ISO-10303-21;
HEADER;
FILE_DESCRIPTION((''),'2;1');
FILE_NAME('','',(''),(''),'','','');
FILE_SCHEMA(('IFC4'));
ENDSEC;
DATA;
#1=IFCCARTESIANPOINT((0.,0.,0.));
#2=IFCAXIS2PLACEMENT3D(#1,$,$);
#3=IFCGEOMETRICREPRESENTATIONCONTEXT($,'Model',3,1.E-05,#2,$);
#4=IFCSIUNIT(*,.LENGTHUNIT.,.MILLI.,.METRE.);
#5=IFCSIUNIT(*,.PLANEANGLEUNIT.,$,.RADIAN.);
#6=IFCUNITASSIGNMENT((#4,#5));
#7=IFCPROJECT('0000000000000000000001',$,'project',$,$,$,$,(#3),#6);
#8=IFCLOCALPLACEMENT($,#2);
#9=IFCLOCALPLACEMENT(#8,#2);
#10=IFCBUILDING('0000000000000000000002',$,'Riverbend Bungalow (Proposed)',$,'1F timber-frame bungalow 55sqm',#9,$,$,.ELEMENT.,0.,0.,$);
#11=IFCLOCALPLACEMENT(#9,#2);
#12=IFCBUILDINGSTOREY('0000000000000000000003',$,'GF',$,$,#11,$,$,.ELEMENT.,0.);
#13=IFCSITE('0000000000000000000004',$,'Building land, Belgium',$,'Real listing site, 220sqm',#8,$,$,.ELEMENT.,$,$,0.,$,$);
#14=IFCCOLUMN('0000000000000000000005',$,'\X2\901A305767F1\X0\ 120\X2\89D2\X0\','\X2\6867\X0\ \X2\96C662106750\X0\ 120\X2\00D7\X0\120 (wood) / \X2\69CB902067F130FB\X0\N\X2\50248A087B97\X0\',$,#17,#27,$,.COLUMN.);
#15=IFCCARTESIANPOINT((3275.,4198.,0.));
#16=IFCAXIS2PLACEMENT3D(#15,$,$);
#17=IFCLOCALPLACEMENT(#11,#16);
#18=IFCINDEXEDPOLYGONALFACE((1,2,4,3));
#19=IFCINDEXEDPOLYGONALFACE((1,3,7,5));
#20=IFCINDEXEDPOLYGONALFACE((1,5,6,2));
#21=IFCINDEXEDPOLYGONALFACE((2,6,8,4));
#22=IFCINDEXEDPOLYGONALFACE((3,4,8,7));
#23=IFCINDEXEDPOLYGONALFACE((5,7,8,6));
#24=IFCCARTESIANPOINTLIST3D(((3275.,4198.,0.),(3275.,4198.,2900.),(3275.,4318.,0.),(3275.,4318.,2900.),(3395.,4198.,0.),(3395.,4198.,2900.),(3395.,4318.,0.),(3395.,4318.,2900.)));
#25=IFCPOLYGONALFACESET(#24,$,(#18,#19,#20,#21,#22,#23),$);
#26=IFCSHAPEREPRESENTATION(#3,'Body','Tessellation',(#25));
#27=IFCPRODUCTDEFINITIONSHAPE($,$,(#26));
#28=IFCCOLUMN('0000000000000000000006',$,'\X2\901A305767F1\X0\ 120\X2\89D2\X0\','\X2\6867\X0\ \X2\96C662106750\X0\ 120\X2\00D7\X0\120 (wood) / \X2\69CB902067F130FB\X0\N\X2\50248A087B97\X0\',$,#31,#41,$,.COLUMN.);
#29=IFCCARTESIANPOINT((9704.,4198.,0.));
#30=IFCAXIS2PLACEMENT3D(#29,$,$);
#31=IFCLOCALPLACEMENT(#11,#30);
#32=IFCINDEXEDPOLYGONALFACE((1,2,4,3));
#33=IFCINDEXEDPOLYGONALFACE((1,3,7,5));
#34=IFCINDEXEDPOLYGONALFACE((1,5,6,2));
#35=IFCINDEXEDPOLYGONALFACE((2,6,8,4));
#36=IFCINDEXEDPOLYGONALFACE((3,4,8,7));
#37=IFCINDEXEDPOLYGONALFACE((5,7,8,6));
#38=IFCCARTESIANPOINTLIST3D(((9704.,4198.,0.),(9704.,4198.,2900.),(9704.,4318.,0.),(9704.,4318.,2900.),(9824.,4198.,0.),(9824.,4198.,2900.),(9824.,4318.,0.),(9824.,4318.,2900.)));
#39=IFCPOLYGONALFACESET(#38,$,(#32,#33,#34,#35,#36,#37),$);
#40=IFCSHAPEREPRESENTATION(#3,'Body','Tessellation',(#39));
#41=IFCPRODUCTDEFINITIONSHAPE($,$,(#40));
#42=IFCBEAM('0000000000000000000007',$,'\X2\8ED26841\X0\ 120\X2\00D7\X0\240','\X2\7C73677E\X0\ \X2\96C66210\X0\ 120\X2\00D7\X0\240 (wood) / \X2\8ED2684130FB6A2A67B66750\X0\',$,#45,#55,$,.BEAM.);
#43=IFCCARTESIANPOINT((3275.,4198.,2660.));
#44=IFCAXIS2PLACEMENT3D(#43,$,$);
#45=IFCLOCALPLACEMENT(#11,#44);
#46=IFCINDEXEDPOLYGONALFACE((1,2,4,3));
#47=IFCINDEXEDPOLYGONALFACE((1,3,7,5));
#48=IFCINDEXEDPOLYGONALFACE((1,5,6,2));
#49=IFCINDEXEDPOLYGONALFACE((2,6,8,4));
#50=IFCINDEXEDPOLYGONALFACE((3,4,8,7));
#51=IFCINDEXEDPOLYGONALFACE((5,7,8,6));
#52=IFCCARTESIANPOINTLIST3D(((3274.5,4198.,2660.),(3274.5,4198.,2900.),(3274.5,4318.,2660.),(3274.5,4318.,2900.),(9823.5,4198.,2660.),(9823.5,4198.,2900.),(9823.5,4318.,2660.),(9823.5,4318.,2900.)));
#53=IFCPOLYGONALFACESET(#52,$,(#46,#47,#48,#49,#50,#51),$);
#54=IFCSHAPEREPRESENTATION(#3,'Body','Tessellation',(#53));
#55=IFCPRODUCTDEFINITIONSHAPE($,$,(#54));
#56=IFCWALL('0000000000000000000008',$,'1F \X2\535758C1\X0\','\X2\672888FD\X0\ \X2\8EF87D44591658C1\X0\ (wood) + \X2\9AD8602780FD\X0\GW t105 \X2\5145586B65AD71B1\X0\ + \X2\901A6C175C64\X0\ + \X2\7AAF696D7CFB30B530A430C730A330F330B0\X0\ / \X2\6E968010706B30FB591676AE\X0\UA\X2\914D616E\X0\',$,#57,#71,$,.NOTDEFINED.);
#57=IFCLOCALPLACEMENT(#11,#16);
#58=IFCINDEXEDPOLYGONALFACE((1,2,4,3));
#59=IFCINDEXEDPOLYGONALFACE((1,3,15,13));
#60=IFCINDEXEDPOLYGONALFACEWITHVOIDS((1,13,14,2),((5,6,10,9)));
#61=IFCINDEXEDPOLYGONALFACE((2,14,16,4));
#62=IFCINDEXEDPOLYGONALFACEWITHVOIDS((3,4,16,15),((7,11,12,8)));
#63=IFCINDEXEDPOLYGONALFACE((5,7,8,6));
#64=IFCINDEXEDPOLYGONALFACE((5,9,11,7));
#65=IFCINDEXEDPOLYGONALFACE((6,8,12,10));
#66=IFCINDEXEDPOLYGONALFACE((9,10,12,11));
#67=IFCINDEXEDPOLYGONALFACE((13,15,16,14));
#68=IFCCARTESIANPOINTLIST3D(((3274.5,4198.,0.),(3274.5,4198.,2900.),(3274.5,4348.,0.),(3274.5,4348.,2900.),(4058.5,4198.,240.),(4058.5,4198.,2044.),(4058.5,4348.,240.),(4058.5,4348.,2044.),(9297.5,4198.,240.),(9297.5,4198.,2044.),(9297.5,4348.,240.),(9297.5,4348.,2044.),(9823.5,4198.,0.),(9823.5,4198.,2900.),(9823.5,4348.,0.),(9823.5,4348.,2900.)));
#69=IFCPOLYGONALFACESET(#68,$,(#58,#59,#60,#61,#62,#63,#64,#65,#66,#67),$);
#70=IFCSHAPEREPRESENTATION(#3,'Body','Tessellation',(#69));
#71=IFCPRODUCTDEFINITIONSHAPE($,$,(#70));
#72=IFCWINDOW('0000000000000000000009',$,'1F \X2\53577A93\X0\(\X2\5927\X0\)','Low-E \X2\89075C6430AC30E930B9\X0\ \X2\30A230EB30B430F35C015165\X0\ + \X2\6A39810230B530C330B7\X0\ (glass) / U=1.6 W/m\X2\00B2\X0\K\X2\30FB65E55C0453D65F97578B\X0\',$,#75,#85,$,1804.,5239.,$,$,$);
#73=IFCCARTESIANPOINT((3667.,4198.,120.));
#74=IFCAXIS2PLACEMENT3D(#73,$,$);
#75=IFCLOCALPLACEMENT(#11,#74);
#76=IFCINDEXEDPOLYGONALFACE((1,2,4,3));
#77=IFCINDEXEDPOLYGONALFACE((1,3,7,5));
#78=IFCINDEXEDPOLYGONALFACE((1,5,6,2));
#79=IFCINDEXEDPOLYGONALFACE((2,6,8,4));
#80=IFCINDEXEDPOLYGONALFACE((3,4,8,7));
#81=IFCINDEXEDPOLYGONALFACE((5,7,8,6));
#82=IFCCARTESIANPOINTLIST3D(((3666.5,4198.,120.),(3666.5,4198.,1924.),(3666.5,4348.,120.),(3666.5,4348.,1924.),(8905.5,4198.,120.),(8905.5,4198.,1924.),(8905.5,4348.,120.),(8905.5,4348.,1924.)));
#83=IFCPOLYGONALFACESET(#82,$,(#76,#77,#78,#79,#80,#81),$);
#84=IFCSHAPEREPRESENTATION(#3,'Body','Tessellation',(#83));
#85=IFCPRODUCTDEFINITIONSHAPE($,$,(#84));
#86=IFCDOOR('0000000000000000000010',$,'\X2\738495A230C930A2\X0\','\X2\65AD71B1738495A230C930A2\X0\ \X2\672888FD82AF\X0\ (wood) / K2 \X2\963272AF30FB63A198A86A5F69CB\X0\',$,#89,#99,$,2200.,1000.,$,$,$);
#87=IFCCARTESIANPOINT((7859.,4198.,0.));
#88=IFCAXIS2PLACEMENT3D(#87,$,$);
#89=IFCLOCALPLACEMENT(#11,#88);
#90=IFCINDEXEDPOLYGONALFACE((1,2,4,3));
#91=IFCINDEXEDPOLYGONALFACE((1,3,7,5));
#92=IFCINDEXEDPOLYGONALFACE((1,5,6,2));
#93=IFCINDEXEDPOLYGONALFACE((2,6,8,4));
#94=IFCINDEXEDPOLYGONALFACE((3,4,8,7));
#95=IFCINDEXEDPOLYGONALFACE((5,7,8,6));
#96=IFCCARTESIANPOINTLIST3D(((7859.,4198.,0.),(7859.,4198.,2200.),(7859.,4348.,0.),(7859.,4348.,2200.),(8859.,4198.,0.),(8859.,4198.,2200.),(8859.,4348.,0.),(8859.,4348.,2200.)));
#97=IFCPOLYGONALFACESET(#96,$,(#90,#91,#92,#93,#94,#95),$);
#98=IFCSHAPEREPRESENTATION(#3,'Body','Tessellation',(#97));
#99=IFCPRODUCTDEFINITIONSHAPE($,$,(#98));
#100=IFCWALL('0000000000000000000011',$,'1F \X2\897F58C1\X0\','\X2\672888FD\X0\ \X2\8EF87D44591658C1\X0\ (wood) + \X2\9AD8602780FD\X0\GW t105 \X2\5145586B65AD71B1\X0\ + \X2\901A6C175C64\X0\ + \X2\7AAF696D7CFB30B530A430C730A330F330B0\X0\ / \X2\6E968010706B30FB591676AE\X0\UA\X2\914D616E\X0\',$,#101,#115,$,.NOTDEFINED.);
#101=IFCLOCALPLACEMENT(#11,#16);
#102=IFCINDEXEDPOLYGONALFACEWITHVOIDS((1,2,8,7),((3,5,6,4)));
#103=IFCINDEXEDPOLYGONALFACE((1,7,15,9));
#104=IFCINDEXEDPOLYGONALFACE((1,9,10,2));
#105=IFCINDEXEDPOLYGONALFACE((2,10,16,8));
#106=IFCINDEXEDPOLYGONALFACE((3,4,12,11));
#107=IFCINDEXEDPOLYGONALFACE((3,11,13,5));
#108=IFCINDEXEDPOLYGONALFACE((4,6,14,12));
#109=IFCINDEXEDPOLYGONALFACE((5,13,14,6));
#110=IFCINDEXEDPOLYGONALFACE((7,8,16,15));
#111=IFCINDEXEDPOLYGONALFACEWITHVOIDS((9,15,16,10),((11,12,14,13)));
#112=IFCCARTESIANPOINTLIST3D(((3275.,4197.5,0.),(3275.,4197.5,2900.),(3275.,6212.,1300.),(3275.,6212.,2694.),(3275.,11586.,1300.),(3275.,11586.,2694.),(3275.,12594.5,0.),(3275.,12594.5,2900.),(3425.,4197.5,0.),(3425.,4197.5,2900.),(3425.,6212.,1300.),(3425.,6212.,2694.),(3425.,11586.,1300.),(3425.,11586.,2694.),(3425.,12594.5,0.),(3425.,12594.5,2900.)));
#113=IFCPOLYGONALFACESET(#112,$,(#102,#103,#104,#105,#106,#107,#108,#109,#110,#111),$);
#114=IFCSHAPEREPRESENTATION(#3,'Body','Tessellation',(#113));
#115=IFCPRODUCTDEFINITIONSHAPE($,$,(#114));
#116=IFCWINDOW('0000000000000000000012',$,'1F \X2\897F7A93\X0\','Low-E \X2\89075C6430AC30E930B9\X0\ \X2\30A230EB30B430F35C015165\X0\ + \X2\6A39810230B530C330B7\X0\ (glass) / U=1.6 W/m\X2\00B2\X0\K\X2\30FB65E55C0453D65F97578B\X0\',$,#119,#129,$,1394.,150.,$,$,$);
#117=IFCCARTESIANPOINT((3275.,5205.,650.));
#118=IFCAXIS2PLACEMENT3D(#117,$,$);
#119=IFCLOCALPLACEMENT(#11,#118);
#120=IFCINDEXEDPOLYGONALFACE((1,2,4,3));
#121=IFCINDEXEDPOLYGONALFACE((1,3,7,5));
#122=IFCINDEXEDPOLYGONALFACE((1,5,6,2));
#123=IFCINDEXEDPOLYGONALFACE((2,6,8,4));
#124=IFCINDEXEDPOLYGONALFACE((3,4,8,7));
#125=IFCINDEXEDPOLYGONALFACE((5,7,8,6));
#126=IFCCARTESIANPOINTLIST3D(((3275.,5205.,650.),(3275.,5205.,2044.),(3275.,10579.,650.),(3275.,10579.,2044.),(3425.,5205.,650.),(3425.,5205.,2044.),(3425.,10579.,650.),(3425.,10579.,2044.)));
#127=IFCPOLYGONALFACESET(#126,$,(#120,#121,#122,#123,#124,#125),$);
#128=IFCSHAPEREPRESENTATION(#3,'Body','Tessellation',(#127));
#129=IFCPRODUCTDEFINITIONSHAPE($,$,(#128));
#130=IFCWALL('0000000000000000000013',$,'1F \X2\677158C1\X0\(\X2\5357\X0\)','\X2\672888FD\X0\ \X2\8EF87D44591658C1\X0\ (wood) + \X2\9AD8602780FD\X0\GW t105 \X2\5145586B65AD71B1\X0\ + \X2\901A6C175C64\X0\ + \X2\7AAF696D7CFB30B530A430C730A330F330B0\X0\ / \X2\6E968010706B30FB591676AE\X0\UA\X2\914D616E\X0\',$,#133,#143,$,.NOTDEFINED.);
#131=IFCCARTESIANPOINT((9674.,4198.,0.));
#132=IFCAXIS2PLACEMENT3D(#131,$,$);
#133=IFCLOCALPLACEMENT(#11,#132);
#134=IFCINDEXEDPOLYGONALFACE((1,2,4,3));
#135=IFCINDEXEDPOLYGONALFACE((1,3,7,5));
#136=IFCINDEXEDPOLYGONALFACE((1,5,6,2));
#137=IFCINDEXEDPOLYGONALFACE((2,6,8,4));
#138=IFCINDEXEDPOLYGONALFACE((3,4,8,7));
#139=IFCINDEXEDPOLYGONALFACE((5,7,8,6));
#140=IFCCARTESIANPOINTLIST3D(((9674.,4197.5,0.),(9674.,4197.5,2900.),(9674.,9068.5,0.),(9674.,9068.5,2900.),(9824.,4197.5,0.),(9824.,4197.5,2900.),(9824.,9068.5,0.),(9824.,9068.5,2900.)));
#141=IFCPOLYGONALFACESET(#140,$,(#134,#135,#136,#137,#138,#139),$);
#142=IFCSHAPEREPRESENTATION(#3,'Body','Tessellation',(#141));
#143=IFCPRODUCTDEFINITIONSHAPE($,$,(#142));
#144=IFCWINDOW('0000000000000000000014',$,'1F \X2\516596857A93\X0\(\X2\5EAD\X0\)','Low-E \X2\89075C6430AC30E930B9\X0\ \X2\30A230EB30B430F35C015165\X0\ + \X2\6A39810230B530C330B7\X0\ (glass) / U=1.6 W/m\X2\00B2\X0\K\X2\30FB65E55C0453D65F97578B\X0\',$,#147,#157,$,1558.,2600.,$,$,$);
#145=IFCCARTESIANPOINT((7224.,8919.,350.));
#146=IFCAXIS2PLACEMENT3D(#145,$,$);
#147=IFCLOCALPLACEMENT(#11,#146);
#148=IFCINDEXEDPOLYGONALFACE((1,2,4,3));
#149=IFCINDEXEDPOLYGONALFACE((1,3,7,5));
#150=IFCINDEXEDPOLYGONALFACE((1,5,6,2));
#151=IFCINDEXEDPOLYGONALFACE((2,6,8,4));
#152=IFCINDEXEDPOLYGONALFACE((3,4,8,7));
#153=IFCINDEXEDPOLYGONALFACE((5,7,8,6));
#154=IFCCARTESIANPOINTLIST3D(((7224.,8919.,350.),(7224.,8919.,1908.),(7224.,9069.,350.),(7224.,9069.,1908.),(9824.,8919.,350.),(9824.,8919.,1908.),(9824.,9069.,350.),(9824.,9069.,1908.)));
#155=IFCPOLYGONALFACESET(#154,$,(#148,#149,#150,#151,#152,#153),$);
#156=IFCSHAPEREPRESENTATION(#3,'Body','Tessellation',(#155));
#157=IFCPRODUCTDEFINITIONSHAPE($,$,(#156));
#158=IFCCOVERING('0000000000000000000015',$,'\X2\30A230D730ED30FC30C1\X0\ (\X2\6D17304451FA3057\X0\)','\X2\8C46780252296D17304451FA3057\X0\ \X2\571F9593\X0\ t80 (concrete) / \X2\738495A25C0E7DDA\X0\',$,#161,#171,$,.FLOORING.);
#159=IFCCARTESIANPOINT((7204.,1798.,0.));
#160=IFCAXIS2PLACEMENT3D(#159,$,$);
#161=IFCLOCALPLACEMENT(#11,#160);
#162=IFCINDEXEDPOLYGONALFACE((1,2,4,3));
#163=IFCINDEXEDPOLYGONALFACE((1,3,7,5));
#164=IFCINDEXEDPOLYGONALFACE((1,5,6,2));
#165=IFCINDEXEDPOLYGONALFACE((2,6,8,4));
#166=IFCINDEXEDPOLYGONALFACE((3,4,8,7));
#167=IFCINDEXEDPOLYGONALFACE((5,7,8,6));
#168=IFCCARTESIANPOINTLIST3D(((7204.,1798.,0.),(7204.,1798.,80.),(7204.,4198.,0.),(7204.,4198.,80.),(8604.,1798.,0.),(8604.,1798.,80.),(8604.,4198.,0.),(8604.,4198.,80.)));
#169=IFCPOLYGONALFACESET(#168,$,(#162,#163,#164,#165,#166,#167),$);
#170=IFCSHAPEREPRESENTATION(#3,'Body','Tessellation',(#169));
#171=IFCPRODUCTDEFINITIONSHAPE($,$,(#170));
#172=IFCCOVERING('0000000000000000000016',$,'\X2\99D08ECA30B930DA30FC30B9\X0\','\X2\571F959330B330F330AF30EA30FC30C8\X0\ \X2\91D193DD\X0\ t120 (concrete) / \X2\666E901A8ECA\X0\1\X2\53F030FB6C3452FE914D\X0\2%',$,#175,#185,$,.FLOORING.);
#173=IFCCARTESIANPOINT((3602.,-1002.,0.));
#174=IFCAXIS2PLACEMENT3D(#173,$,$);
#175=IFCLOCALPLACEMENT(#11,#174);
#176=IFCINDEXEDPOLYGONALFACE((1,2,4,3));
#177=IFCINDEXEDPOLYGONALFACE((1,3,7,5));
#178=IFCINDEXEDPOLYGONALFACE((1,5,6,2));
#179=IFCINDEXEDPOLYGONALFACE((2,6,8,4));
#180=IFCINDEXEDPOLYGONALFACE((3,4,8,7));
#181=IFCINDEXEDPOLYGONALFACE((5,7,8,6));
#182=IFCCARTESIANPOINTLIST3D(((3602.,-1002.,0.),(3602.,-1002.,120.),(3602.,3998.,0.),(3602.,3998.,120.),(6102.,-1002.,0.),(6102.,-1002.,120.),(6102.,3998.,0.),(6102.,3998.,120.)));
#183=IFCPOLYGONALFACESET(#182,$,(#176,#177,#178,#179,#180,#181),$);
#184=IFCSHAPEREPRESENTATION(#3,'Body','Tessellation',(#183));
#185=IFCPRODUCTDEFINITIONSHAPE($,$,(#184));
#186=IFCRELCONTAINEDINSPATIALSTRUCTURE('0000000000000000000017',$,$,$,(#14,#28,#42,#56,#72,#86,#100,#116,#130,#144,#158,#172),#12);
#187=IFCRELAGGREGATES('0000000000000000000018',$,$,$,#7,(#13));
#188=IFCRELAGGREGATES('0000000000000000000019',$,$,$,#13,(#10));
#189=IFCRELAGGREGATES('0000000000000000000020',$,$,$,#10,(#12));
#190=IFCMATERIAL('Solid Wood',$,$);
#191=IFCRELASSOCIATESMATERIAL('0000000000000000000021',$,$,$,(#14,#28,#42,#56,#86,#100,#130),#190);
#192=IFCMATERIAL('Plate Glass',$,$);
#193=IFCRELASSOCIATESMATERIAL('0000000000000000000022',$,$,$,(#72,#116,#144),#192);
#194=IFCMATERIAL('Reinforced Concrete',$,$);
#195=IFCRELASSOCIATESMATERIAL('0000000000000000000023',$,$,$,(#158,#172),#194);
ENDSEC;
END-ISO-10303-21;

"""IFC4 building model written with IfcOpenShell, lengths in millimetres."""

from ifc_helpers import new_model, si_unit, frame, frame_2d, origin, place, context, project, spatial, rectangle, extrude, material, element, fill, save


model = new_model("IFC4")

# Units and contexts
model_context = context("Model", 3, precision=1e-05, world=origin())
ifc_project = project(units=[si_unit("LENGTHUNIT", "METRE", prefix="MILLI"), si_unit("PLANEANGLEUNIT", "RADIAN")], contexts=[model_context])

# Site, building, storey
site_placement = place(None, origin())
site = spatial("IfcSite", under=ifc_project, at=site_placement, Name="Building land, Belgium", ObjectType="Real listing site, 220sqm", CompositionType="ELEMENT", RefElevation=0.0)
building_placement = place(site_placement, origin())
building = spatial("IfcBuilding", under=site, at=building_placement, Name="Riverbend Bungalow (Proposed)", ObjectType="1F timber-frame bungalow 55sqm", CompositionType="ELEMENT", ElevationOfRefHeight=0.0, ElevationOfTerrain=0.0)
storey_placement = place(building_placement, origin())
storey = spatial("IfcBuildingStorey", under=building, at=storey_placement, Name="GF", CompositionType="ELEMENT", Elevation=0.0)

# Columns
ifc_material_1 = material(Name="Solid Wood")
column_1_placement = place(storey_placement, frame((3275.0, 4198.0, 0.0)))
element("IfcColumn", 1, at=column_1_placement, inside=storey, material=ifc_material_1, Name="通し柱 120角", Description="桧 集成材 120×120 (wood) / 構造柱・N値計算", PredefinedType="COLUMN", context=model_context, shape_type="SweptSolid", body=[
    extrude(rectangle(XDim=120.0, YDim=120.0, at=frame_2d((60.0, 60.0))), frame((3275.0, 4198.0, 0.0)), (0.0, 0.0, 1.0), 2900.0),
])
column_2_placement = place(storey_placement, frame((9704.0, 4198.0, 0.0)))
element("IfcColumn", 2, at=column_2_placement, inside=storey, material=ifc_material_1, Name="通し柱 120角", Description="桧 集成材 120×120 (wood) / 構造柱・N値計算", PredefinedType="COLUMN", context=model_context, shape_type="SweptSolid", body=[
    extrude(rectangle(XDim=120.0, YDim=120.0, at=frame_2d((60.0, 60.0))), frame((9704.0, 4198.0, 0.0)), (0.0, 0.0, 1.0), 2900.0),
])

# Beam
beam_1_placement = place(storey_placement, frame((3275.0, 4198.0, 2660.0)))
element("IfcBeam", 3, at=beam_1_placement, inside=storey, material=ifc_material_1, Name="軒桁 120×240", Description="米松 集成 120×240 (wood) / 軒桁・横架材", PredefinedType="BEAM", context=model_context, shape_type="SweptSolid", body=[
    extrude(rectangle(XDim=6549.0, YDim=120.0, at=frame_2d((3274.0, 60.0))), frame((3275.0, 4198.0, 2660.0)), (0.0, 0.0, 1.0), 240.0),
])

# Shared definitions
ifc_material_2 = material(Name="Reinforced Concrete")

# Wall, openings, window, door
wall_1_placement = place(storey_placement, frame((3275.0, 4198.0, 0.0)))
wall_1 = element("IfcWall", 4, at=wall_1_placement, inside=storey, material=ifc_material_1, Name="1F 南壁", Description="木製 軸組外壁 (wood) + 高性能GW t105 充填断熱 + 通気層 + 窯業系サイディング / 準耐火・外皮UA配慮", PredefinedType="NOTDEFINED", context=model_context, shape_type="SweptSolid", body=[
    extrude(rectangle(XDim=6549.0, YDim=150.0, at=frame_2d((3274.0, 75.0))), frame((3275.0, 4198.0, 0.0)), (0.0, 0.0, 1.0), 2900.0),
])
opening_1_placement = place(storey_placement, frame((3667.0, 4198.0, 120.0)))
opening_1 = element("IfcOpeningElement", 5, at=opening_1_placement, cuts=wall_1, PredefinedType="NOTDEFINED", context=model_context, shape_type="SweptSolid", body=[
    extrude(rectangle(XDim=5239.0, YDim=150.0, at=frame_2d((2619.0, 75.0))), frame((3667.0, 4198.0, 120.0)), (0.0, 0.0, 1.0), 1804.0),
])
opening_2_placement = place(storey_placement, frame((7859.0, 4198.0, 0.0)))
opening_2 = element("IfcOpeningElement", 6, at=opening_2_placement, cuts=wall_1, PredefinedType="NOTDEFINED", context=model_context, shape_type="SweptSolid", body=[
    extrude(rectangle(XDim=1000.0, YDim=150.0, at=frame_2d((500.0, 75.0))), frame((7859.0, 4198.0, 0.0)), (0.0, 0.0, 1.0), 2200.0),
])
ifc_material_3 = material(Name="Plate Glass")
window_1_placement = place(storey_placement, frame((3667.0, 4198.0, 120.0)))
window_1 = element("IfcWindow", 7, at=window_1_placement, inside=storey, material=ifc_material_3, Name="1F 南窓(大)", Description="Low-E 複層ガラス アルゴン封入 + 樹脂サッシ (glass) / U=1.6 W/m²K・日射取得型", OverallHeight=1804.0, OverallWidth=5239.0, context=model_context, shape_type="SweptSolid", body=[
    extrude(rectangle(XDim=5239.0, YDim=150.0, at=frame_2d((2619.0, 75.0))), frame((3667.0, 4198.0, 120.0)), (0.0, 0.0, 1.0), 1804.0),
])
fill(opening_1, window_1)
door_1_placement = place(storey_placement, frame((7859.0, 4198.0, 0.0)))
door_1 = element("IfcDoor", 8, at=door_1_placement, inside=storey, material=ifc_material_1, Name="玄関ドア", Description="断熱玄関ドア 木製芯 (wood) / K2 防犯・採風機構", OverallHeight=2200.0, OverallWidth=1000.0, context=model_context, shape_type="SweptSolid", body=[
    extrude(rectangle(XDim=1000.0, YDim=150.0, at=frame_2d((500.0, 75.0))), frame((7859.0, 4198.0, 0.0)), (0.0, 0.0, 1.0), 2200.0),
])
fill(opening_2, door_1)

# Walls, openings, windows
wall_2_placement = place(storey_placement, frame((3275.0, 4198.0, 0.0)))
wall_2 = element("IfcWall", 9, at=wall_2_placement, inside=storey, material=ifc_material_1, Name="1F 西壁", Description="木製 軸組外壁 (wood) + 高性能GW t105 充填断熱 + 通気層 + 窯業系サイディング / 準耐火・外皮UA配慮", PredefinedType="NOTDEFINED", context=model_context, shape_type="SweptSolid", body=[
    extrude(rectangle(XDim=150.0, YDim=8397.0, at=frame_2d((75.0, 4198.0))), frame((3275.0, 4198.0, 0.0)), (0.0, 0.0, 1.0), 2900.0),
])
opening_3_placement = place(storey_placement, frame((3275.0, 5205.0, 650.0)))
opening_3 = element("IfcOpeningElement", 10, at=opening_3_placement, cuts=wall_2, PredefinedType="NOTDEFINED", context=model_context, shape_type="SweptSolid", body=[
    extrude(rectangle(XDim=150.0, YDim=5374.0, at=frame_2d((75.0, 2687.0))), frame((3275.0, 5205.0, 650.0)), (0.0, 0.0, 1.0), 1394.0),
])
window_2_placement = place(storey_placement, frame((3275.0, 5205.0, 650.0)))
window_2 = element("IfcWindow", 11, at=window_2_placement, inside=storey, material=ifc_material_3, Name="1F 西窓", Description="Low-E 複層ガラス アルゴン封入 + 樹脂サッシ (glass) / U=1.6 W/m²K・日射取得型", OverallHeight=1394.0, OverallWidth=150.0, context=model_context, shape_type="SweptSolid", body=[
    extrude(rectangle(XDim=150.0, YDim=5374.0, at=frame_2d((75.0, 2687.0))), frame((3275.0, 5205.0, 650.0)), (0.0, 0.0, 1.0), 1394.0),
])
fill(opening_3, window_2)
wall_3_placement = place(storey_placement, frame((9674.0, 4198.0, 0.0)))
wall_3 = element("IfcWall", 12, at=wall_3_placement, inside=storey, material=ifc_material_1, Name="1F 東壁(南)", Description="木製 軸組外壁 (wood) + 高性能GW t105 充填断熱 + 通気層 + 窯業系サイディング / 準耐火・外皮UA配慮", PredefinedType="NOTDEFINED", context=model_context, shape_type="SweptSolid", body=[
    extrude(rectangle(XDim=150.0, YDim=4871.0, at=frame_2d((75.0, 2435.0))), frame((9674.0, 4198.0, 0.0)), (0.0, 0.0, 1.0), 2900.0),
])
opening_4_placement = place(storey_placement, frame((7224.0, 8919.0, 350.0)))
opening_4 = element("IfcOpeningElement", 13, at=opening_4_placement, cuts=wall_3, PredefinedType="NOTDEFINED", context=model_context, shape_type="SweptSolid", body=[
    extrude(rectangle(XDim=2600.0, YDim=150.0, at=frame_2d((1300.0, 75.0))), frame((7224.0, 8919.0, 350.0)), (0.0, 0.0, 1.0), 1558.0),
])
window_3_placement = place(storey_placement, frame((7224.0, 8919.0, 350.0)))
window_3 = element("IfcWindow", 14, at=window_3_placement, inside=storey, material=ifc_material_3, Name="1F 入隅窓(庭)", Description="Low-E 複層ガラス アルゴン封入 + 樹脂サッシ (glass) / U=1.6 W/m²K・日射取得型", OverallHeight=1558.0, OverallWidth=2600.0, context=model_context, shape_type="SweptSolid", body=[
    extrude(rectangle(XDim=2600.0, YDim=150.0, at=frame_2d((1300.0, 75.0))), frame((7224.0, 8919.0, 350.0)), (0.0, 0.0, 1.0), 1558.0),
])
fill(opening_4, window_3)

# Coverings
covering_1_placement = place(storey_placement, frame((7204.0, 1798.0, 0.0)))
element("IfcCovering", 15, at=covering_1_placement, inside=storey, material=ifc_material_2, Name="アプローチ (洗い出し)", Description="豆砂利洗い出し 土間 t80 (concrete) / 玄関導線", PredefinedType="FLOORING", context=model_context, shape_type="SweptSolid", body=[
    extrude(rectangle(XDim=1400.0, YDim=2400.0, at=frame_2d((700.0, 1200.0))), frame((7204.0, 1798.0, 0.0)), (0.0, 0.0, 1.0), 80.0),
])
covering_2_placement = place(storey_placement, frame((3602.0, -1002.0, 0.0)))
element("IfcCovering", 16, at=covering_2_placement, inside=storey, material=ifc_material_2, Name="駐車スペース", Description="土間コンクリート 金鏝 t120 (concrete) / 普通車1台・水勾配2%", PredefinedType="FLOORING", context=model_context, shape_type="SweptSolid", body=[
    extrude(rectangle(XDim=2500.0, YDim=5000.0, at=frame_2d((1250.0, 2500.0))), frame((3602.0, -1002.0, 0.0)), (0.0, 0.0, 1.0), 120.0),
])

save(model, "model.ifc")
